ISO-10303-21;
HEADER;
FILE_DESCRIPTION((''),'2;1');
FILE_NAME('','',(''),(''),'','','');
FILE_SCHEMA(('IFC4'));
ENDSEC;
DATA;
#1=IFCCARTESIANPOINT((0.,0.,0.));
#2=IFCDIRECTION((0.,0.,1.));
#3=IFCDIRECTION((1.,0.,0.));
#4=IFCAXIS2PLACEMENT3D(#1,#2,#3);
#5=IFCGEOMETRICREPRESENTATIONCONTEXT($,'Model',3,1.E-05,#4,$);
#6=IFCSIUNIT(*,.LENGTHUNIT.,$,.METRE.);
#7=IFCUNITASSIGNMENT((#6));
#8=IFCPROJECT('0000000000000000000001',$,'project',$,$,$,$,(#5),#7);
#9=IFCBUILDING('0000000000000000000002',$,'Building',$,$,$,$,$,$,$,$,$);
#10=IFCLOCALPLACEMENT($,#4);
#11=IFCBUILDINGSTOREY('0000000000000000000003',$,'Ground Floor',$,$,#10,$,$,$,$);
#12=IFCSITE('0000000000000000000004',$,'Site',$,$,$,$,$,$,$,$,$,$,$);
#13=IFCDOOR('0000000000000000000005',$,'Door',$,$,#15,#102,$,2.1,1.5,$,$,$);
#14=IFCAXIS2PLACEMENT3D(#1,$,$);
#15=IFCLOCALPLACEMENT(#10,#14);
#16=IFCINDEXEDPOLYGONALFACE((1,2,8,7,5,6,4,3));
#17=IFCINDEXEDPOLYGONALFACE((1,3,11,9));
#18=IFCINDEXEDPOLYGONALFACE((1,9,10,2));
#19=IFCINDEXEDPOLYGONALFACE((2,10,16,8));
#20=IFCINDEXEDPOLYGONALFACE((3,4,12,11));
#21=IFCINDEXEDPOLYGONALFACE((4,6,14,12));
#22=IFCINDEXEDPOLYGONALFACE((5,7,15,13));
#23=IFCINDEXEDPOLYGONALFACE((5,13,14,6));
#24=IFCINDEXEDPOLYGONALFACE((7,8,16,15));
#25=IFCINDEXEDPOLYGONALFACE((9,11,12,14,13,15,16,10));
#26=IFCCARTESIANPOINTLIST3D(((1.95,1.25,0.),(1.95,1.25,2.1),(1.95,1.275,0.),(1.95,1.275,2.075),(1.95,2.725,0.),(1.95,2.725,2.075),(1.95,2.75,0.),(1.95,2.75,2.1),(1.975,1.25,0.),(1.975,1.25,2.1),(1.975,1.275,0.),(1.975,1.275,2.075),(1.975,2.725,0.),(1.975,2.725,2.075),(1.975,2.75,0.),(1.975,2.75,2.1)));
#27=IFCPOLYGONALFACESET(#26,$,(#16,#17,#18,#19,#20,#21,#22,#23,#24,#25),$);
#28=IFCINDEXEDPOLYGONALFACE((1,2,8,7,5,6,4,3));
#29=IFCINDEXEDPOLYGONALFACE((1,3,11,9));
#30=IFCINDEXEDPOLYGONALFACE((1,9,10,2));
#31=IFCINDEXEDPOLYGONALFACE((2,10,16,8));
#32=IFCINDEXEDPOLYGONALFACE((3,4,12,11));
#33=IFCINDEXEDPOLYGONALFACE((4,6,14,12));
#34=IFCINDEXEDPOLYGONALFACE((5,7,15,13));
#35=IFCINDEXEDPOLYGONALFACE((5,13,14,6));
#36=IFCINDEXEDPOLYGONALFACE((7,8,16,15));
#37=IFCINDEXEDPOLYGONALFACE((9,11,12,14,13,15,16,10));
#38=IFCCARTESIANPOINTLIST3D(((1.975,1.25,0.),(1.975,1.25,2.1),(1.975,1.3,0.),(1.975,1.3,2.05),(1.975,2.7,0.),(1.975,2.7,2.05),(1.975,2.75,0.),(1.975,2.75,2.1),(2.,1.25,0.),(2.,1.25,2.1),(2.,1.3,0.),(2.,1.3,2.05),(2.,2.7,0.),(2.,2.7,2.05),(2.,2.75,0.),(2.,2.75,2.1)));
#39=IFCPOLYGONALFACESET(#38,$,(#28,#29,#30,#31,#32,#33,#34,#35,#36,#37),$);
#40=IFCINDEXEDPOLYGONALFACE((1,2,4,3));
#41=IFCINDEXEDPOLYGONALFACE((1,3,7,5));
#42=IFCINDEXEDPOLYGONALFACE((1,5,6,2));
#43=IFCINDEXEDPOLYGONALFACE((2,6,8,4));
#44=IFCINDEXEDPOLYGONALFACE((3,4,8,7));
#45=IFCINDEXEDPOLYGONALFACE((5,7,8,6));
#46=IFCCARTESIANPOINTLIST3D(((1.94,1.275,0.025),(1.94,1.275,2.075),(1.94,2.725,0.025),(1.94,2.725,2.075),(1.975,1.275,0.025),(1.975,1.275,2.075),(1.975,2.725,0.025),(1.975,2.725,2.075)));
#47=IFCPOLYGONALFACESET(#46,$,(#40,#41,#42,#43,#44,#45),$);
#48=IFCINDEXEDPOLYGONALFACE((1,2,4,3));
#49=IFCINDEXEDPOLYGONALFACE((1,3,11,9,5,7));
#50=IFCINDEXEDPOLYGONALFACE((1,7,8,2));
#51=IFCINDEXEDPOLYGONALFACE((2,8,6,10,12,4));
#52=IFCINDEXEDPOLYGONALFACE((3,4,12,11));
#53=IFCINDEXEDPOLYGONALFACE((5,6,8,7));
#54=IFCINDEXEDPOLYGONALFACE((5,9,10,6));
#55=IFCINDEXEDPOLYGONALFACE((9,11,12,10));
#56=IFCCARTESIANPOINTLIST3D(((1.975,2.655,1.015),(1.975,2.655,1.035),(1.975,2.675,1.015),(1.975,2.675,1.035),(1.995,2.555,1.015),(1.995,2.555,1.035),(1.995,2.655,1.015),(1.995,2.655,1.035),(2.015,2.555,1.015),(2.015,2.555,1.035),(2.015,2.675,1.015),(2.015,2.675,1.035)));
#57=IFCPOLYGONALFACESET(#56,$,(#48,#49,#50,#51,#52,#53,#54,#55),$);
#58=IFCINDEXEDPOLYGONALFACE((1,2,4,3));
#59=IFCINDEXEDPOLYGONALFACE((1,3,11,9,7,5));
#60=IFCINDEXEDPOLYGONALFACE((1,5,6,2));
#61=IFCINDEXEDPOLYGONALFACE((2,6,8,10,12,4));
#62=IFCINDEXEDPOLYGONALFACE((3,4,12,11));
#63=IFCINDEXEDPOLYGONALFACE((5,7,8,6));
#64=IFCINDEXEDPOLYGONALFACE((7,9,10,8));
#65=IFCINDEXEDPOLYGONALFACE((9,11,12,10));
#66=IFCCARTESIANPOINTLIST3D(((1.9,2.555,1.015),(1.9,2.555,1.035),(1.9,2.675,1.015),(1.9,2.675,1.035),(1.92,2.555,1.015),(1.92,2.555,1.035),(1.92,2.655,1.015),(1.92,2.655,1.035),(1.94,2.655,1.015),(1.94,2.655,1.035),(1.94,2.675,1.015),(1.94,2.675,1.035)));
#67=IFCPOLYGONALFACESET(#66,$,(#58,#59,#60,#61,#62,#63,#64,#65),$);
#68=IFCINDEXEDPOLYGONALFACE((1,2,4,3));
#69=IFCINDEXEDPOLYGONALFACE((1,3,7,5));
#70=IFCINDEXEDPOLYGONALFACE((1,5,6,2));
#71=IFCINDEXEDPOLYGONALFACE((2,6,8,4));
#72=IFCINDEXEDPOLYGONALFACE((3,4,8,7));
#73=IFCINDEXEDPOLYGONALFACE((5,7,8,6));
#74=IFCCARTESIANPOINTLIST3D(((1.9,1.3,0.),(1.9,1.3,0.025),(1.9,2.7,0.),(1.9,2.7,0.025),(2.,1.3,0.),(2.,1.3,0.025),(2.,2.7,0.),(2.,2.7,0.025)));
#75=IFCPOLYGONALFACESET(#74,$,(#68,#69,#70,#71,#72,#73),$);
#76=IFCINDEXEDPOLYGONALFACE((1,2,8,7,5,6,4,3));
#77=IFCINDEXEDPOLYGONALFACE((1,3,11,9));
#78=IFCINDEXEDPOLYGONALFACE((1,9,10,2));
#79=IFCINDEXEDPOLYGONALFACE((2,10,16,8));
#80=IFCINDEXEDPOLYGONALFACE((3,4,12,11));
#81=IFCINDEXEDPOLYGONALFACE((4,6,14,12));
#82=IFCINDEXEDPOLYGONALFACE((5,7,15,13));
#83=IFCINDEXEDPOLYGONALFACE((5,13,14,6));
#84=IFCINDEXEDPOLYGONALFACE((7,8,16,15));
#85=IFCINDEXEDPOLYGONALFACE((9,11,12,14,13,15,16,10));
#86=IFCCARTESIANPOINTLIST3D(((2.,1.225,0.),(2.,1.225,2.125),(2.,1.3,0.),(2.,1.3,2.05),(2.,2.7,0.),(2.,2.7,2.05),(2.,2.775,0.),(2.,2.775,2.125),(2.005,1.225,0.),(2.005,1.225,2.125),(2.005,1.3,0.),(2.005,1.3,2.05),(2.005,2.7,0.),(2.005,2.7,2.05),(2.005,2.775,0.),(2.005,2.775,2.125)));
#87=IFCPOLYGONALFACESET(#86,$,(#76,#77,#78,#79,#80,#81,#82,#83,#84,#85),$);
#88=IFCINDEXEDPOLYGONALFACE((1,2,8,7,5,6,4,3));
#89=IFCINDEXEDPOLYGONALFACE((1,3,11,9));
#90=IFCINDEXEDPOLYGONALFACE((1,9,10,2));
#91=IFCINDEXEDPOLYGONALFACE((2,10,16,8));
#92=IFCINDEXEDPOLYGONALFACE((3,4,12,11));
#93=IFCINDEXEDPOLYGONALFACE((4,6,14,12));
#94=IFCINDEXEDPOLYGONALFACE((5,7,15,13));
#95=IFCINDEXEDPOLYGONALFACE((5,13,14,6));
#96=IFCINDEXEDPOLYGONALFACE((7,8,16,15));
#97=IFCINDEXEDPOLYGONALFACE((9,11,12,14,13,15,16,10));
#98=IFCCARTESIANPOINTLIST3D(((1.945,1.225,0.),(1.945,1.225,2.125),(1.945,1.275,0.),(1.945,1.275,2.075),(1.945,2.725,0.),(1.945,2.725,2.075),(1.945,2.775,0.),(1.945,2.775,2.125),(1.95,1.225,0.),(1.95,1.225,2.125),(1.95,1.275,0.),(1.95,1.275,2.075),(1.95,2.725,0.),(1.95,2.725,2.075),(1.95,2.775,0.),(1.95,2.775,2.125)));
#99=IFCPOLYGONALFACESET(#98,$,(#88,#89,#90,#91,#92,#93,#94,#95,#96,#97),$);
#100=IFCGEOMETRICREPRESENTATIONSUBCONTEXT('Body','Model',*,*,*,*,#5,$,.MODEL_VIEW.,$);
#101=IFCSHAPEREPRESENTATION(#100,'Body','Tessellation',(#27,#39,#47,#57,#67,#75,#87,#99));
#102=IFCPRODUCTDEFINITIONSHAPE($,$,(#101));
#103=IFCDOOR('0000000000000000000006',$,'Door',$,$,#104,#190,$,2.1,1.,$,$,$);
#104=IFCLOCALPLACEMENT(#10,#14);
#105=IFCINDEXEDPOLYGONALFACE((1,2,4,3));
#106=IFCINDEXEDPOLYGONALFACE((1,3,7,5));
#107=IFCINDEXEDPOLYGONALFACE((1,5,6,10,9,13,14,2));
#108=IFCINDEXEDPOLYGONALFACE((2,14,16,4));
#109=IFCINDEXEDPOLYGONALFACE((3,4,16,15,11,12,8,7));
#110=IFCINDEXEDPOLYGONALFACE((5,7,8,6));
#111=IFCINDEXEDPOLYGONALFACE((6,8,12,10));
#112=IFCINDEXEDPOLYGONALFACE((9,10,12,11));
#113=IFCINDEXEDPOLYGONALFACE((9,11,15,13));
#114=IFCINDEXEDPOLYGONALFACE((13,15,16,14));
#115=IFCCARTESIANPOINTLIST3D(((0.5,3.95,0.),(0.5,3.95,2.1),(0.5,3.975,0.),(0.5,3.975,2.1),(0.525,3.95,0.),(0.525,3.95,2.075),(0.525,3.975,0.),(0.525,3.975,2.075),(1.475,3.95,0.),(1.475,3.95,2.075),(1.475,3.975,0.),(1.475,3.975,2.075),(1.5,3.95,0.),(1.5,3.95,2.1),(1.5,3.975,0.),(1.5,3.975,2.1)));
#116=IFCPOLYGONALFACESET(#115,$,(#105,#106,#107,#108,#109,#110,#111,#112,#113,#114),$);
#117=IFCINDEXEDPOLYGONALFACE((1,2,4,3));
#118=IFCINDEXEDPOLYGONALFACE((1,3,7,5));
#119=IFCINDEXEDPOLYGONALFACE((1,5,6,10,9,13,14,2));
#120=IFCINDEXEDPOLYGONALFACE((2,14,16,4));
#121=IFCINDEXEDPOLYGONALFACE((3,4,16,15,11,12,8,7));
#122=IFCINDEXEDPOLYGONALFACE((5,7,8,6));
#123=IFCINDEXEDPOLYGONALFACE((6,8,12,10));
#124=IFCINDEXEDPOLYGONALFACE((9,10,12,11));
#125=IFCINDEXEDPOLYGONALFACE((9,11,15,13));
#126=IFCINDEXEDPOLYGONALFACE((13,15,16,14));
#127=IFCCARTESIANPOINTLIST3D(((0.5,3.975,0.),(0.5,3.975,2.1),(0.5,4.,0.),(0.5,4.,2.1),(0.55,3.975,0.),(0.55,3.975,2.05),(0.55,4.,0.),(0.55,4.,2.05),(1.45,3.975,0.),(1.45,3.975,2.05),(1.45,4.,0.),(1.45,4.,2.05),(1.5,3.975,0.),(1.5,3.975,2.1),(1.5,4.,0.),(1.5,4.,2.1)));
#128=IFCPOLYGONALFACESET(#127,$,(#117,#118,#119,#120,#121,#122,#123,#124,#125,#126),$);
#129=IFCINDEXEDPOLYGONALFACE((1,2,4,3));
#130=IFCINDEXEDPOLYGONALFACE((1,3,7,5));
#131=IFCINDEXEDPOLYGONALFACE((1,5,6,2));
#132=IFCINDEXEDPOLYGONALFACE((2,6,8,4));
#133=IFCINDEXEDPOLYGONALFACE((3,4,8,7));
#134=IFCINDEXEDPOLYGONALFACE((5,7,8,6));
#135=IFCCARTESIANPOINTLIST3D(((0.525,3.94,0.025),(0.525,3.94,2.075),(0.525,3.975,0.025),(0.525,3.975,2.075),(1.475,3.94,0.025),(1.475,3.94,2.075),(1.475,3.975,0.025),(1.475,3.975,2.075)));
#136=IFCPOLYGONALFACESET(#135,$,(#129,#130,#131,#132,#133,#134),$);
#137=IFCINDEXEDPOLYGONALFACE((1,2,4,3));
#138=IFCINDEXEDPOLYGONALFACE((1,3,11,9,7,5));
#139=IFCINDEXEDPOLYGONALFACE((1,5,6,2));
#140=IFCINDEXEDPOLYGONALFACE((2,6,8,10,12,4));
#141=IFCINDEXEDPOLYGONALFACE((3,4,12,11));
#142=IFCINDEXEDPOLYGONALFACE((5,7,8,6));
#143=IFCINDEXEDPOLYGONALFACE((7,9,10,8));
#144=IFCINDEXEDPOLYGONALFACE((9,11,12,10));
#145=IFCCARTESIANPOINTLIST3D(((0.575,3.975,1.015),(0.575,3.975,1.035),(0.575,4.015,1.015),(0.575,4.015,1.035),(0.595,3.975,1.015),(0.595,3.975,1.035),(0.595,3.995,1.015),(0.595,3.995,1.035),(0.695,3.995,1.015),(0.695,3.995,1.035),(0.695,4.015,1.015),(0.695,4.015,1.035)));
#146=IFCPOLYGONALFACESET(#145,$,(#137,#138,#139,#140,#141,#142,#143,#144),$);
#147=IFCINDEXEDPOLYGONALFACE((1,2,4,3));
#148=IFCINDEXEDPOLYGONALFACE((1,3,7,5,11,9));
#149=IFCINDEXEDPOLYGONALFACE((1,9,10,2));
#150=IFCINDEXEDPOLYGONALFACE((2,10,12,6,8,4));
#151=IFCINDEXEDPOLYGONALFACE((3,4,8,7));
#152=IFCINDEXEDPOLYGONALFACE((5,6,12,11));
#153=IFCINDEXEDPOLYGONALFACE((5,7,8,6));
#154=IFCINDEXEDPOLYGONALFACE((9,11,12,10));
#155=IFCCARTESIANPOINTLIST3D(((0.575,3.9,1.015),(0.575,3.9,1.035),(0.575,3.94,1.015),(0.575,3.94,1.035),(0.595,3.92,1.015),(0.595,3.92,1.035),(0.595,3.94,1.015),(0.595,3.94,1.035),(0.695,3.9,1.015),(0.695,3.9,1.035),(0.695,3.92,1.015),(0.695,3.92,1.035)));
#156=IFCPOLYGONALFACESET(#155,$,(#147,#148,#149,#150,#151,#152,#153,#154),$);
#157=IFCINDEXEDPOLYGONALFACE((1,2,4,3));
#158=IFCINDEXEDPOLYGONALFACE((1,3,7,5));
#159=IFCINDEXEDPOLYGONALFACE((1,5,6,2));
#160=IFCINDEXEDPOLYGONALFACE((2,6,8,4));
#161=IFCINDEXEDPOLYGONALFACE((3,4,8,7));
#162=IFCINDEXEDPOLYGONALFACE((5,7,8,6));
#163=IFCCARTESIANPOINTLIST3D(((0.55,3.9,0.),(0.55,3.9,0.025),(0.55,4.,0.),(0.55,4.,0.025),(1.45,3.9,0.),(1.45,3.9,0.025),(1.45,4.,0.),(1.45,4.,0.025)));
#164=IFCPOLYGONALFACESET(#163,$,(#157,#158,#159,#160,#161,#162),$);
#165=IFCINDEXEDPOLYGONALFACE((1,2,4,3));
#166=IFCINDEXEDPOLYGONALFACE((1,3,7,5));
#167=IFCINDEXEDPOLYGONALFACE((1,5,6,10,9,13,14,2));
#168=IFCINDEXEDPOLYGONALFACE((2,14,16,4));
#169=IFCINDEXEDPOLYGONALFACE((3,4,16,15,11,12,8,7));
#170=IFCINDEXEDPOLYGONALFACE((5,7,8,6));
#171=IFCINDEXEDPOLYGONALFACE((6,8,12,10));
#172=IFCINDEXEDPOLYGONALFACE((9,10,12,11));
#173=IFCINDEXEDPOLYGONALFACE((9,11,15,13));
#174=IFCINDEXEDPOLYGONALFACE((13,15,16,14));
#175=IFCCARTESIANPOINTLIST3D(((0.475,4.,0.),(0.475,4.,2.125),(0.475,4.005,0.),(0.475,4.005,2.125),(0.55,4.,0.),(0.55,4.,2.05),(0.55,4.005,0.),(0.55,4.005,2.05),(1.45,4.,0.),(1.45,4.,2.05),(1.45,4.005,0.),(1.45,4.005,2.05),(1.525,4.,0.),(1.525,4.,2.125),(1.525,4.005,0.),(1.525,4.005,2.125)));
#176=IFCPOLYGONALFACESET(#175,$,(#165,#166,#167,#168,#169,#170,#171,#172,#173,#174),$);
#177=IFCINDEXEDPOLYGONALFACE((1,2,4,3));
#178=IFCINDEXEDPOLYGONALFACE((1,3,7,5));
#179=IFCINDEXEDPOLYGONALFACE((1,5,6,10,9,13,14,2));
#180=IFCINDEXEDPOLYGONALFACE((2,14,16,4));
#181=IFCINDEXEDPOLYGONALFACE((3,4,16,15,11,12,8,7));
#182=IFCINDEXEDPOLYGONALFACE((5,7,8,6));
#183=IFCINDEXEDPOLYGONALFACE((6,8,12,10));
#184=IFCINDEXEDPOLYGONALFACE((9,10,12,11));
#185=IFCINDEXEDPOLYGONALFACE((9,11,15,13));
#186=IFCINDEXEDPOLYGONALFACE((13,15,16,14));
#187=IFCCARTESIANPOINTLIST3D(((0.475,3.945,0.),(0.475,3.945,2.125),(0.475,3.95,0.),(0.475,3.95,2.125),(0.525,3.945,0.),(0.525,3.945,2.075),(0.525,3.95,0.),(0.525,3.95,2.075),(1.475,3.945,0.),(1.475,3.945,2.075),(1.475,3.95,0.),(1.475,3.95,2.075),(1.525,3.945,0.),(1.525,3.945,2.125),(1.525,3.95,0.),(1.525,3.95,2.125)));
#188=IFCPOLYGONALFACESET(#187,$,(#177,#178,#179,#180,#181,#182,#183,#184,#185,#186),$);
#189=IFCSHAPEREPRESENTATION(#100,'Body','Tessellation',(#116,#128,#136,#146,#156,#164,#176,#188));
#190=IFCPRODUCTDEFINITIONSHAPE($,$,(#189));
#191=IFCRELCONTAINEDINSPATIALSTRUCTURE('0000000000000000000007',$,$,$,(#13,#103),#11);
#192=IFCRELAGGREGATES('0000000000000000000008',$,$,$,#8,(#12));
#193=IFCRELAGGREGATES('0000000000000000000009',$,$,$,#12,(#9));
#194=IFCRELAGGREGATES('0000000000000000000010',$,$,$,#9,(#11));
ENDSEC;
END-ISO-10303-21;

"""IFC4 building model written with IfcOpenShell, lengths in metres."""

from ifc_helpers import new_model, si_unit, frame, origin_with_axes, place, context, subcontext, project, spatial, line, indexed_curve, outline, extrude, element, save


model = new_model("IFC4")

# Units and contexts
model_context = context("Model", 3, precision=1e-05, world=origin_with_axes())
body_context = subcontext(model_context, "Body", "Model", "MODEL_VIEW")
ifc_project = project(units=[si_unit("LENGTHUNIT", "METRE")], contexts=[model_context])

# Site, building, storey
site = spatial("IfcSite", under=ifc_project, Name="Site")
building = spatial("IfcBuilding", under=site, Name="Building")
storey_placement = place(None, origin_with_axes())
storey = spatial("IfcBuildingStorey", under=building, at=storey_placement, Name="Ground Floor")

# Doors
door_1_placement = place(storey_placement, frame((2.0, 1.25, 0.0), z_axis=(0.0, 0.0, 1.0), x_axis=(0.0, 1.0, 0.0)))
element("IfcDoor", 1, at=door_1_placement, inside=storey, Name="Door", OverallHeight=2.1, OverallWidth=1.5, context=body_context, shape_type="SweptSolid", body=[
    extrude(outline(indexed_curve([(0.0, 0.0), (0.0, 2.1), (1.5, 2.1), (1.5, 0.0), (1.475, 0.0), (1.475, 2.075), (0.025, 2.075), (0.025, 0.0)], segments=[line(1, 2, 3, 4, 5, 6, 7, 8, 1)])), frame((0.0, 0.025, 0.0), z_axis=(0.0, -1.0, 0.0), x_axis=(1.0, 0.0, 0.0)), (0.0, 0.0, -1.0), 0.025),
    extrude(outline(indexed_curve([(0.0, 0.0), (0.0, 2.1), (1.5, 2.1), (1.5, 0.0), (1.45, 0.0), (1.45, 2.05), (0.05, 2.05), (0.05, 0.0)], segments=[line(1, 2, 3, 4, 5, 6, 7, 8, 1)])), frame((0.0, 0.0, 0.0), z_axis=(0.0, -1.0, 0.0), x_axis=(1.0, 0.0, 0.0)), (0.0, 0.0, -1.0), 0.025),
    extrude(outline(indexed_curve([(0.0, 0.0), (1.45, 0.0), (1.45, 0.035), (0.0, 0.035)], segments=[line(1, 2, 3, 4, 1)])), frame((0.025, 0.025, 0.025), z_axis=(0.0, 0.0, 1.0), x_axis=(1.0, 0.0, 0.0)), (0.0, 0.0, 1.0), 2.05),
    extrude(outline(indexed_curve([(0.0, 0.0), (0.0, -0.04), (-0.12, -0.04), (-0.12, -0.02), (-0.02, -0.02), (-0.02, 0.0)], segments=[line(1, 2, 3, 4, 5, 6, 1)])), frame((1.425, 0.025, 1.015), z_axis=(0.0, 0.0, 1.0), x_axis=(1.0, 0.0, 0.0)), (0.0, 0.0, 1.0), 0.02),
    extrude(outline(indexed_curve([(0.0, 0.0), (0.0, 0.04), (-0.12, 0.04), (-0.12, 0.02), (-0.02, 0.02), (-0.02, 0.0)], segments=[line(1, 2, 3, 4, 5, 6, 1)])), frame((1.425, 0.06, 1.015), z_axis=(0.0, 0.0, 1.0), x_axis=(1.0, 0.0, 0.0)), (0.0, 0.0, 1.0), 0.02),
    extrude(outline(indexed_curve([(0.0, 0.0), (1.4, 0.0), (1.4, 0.1), (0.0, 0.1)], segments=[line(1, 2, 3, 4, 1)])), frame((0.05, 0.0, 0.0), z_axis=(0.0, 0.0, 1.0), x_axis=(1.0, 0.0, 0.0)), (0.0, 0.0, 1.0), 0.025),
    extrude(outline(indexed_curve([(0.0, 0.0), (0.0, 2.125), (1.55, 2.125), (1.55, 0.0), (1.475, 0.0), (1.475, 2.05), (0.075, 2.05), (0.075, 0.0)], segments=[line(1, 2, 3, 4, 5, 6, 7, 8, 1)])), frame((-0.025, -0.005, 0.0), z_axis=(0.0, -1.0, 0.0), x_axis=(1.0, 0.0, 0.0)), (0.0, 0.0, -1.0), 0.005),
    extrude(outline(indexed_curve([(0.0, 0.0), (0.0, 2.125), (1.55, 2.125), (1.55, 0.0), (1.5, 0.0), (1.5, 2.075), (0.05, 2.075), (0.05, 0.0)], segments=[line(1, 2, 3, 4, 5, 6, 7, 8, 1)])), frame((-0.025, 0.05, 0.0), z_axis=(0.0, -1.0, 0.0), x_axis=(1.0, 0.0, 0.0)), (0.0, 0.0, -1.0), 0.005),
])
door_2_placement = place(storey_placement, frame((1.5, 4.0, 0.0), z_axis=(0.0, 0.0, 1.0), x_axis=(-1.0, 0.0, 0.0)))
element("IfcDoor", 2, at=door_2_placement, inside=storey, Name="Door", OverallHeight=2.1, OverallWidth=1.0, context=body_context, shape_type="SweptSolid", body=[
    extrude(outline(indexed_curve([(0.0, 0.0), (0.0, 2.1), (1.0, 2.1), (1.0, 0.0), (0.975, 0.0), (0.975, 2.075), (0.025, 2.075), (0.025, 0.0)], segments=[line(1, 2, 3, 4, 5, 6, 7, 8, 1)])), frame((0.0, 0.025, 0.0), z_axis=(0.0, -1.0, 0.0), x_axis=(1.0, 0.0, 0.0)), (0.0, 0.0, -1.0), 0.025),
    extrude(outline(indexed_curve([(0.0, 0.0), (0.0, 2.1), (1.0, 2.1), (1.0, 0.0), (0.95, 0.0), (0.95, 2.05), (0.05, 2.05), (0.05, 0.0)], segments=[line(1, 2, 3, 4, 5, 6, 7, 8, 1)])), frame((0.0, 0.0, 0.0), z_axis=(0.0, -1.0, 0.0), x_axis=(1.0, 0.0, 0.0)), (0.0, 0.0, -1.0), 0.025),
    extrude(outline(indexed_curve([(0.0, 0.0), (0.95, 0.0), (0.95, 0.035), (0.0, 0.035)], segments=[line(1, 2, 3, 4, 1)])), frame((0.025, 0.025, 0.025), z_axis=(0.0, 0.0, 1.0), x_axis=(1.0, 0.0, 0.0)), (0.0, 0.0, 1.0), 2.05),
    extrude(outline(indexed_curve([(0.0, 0.0), (0.0, -0.04), (-0.12, -0.04), (-0.12, -0.02), (-0.02, -0.02), (-0.02, 0.0)], segments=[line(1, 2, 3, 4, 5, 6, 1)])), frame((0.925, 0.025, 1.015), z_axis=(0.0, 0.0, 1.0), x_axis=(1.0, 0.0, 0.0)), (0.0, 0.0, 1.0), 0.02),
    extrude(outline(indexed_curve([(0.0, 0.0), (0.0, 0.04), (-0.12, 0.04), (-0.12, 0.02), (-0.02, 0.02), (-0.02, 0.0)], segments=[line(1, 2, 3, 4, 5, 6, 1)])), frame((0.925, 0.06, 1.015), z_axis=(0.0, 0.0, 1.0), x_axis=(1.0, 0.0, 0.0)), (0.0, 0.0, 1.0), 0.02),
    extrude(outline(indexed_curve([(0.0, 0.0), (0.9, 0.0), (0.9, 0.1), (0.0, 0.1)], segments=[line(1, 2, 3, 4, 1)])), frame((0.05, 0.0, 0.0), z_axis=(0.0, 0.0, 1.0), x_axis=(1.0, 0.0, 0.0)), (0.0, 0.0, 1.0), 0.025),
    extrude(outline(indexed_curve([(0.0, 0.0), (0.0, 2.125), (1.05, 2.125), (1.05, 0.0), (0.975, 0.0), (0.975, 2.05), (0.075, 2.05), (0.075, 0.0)], segments=[line(1, 2, 3, 4, 5, 6, 7, 8, 1)])), frame((-0.025, -0.005, 0.0), z_axis=(0.0, -1.0, 0.0), x_axis=(1.0, 0.0, 0.0)), (0.0, 0.0, -1.0), 0.005),
    extrude(outline(indexed_curve([(0.0, 0.0), (0.0, 2.125), (1.05, 2.125), (1.05, 0.0), (1.0, 0.0), (1.0, 2.075), (0.05, 2.075), (0.05, 0.0)], segments=[line(1, 2, 3, 4, 5, 6, 7, 8, 1)])), frame((-0.025, 0.05, 0.0), z_axis=(0.0, -1.0, 0.0), x_axis=(1.0, 0.0, 0.0)), (0.0, 0.0, -1.0), 0.005),
])

save(model, "model.ifc")
